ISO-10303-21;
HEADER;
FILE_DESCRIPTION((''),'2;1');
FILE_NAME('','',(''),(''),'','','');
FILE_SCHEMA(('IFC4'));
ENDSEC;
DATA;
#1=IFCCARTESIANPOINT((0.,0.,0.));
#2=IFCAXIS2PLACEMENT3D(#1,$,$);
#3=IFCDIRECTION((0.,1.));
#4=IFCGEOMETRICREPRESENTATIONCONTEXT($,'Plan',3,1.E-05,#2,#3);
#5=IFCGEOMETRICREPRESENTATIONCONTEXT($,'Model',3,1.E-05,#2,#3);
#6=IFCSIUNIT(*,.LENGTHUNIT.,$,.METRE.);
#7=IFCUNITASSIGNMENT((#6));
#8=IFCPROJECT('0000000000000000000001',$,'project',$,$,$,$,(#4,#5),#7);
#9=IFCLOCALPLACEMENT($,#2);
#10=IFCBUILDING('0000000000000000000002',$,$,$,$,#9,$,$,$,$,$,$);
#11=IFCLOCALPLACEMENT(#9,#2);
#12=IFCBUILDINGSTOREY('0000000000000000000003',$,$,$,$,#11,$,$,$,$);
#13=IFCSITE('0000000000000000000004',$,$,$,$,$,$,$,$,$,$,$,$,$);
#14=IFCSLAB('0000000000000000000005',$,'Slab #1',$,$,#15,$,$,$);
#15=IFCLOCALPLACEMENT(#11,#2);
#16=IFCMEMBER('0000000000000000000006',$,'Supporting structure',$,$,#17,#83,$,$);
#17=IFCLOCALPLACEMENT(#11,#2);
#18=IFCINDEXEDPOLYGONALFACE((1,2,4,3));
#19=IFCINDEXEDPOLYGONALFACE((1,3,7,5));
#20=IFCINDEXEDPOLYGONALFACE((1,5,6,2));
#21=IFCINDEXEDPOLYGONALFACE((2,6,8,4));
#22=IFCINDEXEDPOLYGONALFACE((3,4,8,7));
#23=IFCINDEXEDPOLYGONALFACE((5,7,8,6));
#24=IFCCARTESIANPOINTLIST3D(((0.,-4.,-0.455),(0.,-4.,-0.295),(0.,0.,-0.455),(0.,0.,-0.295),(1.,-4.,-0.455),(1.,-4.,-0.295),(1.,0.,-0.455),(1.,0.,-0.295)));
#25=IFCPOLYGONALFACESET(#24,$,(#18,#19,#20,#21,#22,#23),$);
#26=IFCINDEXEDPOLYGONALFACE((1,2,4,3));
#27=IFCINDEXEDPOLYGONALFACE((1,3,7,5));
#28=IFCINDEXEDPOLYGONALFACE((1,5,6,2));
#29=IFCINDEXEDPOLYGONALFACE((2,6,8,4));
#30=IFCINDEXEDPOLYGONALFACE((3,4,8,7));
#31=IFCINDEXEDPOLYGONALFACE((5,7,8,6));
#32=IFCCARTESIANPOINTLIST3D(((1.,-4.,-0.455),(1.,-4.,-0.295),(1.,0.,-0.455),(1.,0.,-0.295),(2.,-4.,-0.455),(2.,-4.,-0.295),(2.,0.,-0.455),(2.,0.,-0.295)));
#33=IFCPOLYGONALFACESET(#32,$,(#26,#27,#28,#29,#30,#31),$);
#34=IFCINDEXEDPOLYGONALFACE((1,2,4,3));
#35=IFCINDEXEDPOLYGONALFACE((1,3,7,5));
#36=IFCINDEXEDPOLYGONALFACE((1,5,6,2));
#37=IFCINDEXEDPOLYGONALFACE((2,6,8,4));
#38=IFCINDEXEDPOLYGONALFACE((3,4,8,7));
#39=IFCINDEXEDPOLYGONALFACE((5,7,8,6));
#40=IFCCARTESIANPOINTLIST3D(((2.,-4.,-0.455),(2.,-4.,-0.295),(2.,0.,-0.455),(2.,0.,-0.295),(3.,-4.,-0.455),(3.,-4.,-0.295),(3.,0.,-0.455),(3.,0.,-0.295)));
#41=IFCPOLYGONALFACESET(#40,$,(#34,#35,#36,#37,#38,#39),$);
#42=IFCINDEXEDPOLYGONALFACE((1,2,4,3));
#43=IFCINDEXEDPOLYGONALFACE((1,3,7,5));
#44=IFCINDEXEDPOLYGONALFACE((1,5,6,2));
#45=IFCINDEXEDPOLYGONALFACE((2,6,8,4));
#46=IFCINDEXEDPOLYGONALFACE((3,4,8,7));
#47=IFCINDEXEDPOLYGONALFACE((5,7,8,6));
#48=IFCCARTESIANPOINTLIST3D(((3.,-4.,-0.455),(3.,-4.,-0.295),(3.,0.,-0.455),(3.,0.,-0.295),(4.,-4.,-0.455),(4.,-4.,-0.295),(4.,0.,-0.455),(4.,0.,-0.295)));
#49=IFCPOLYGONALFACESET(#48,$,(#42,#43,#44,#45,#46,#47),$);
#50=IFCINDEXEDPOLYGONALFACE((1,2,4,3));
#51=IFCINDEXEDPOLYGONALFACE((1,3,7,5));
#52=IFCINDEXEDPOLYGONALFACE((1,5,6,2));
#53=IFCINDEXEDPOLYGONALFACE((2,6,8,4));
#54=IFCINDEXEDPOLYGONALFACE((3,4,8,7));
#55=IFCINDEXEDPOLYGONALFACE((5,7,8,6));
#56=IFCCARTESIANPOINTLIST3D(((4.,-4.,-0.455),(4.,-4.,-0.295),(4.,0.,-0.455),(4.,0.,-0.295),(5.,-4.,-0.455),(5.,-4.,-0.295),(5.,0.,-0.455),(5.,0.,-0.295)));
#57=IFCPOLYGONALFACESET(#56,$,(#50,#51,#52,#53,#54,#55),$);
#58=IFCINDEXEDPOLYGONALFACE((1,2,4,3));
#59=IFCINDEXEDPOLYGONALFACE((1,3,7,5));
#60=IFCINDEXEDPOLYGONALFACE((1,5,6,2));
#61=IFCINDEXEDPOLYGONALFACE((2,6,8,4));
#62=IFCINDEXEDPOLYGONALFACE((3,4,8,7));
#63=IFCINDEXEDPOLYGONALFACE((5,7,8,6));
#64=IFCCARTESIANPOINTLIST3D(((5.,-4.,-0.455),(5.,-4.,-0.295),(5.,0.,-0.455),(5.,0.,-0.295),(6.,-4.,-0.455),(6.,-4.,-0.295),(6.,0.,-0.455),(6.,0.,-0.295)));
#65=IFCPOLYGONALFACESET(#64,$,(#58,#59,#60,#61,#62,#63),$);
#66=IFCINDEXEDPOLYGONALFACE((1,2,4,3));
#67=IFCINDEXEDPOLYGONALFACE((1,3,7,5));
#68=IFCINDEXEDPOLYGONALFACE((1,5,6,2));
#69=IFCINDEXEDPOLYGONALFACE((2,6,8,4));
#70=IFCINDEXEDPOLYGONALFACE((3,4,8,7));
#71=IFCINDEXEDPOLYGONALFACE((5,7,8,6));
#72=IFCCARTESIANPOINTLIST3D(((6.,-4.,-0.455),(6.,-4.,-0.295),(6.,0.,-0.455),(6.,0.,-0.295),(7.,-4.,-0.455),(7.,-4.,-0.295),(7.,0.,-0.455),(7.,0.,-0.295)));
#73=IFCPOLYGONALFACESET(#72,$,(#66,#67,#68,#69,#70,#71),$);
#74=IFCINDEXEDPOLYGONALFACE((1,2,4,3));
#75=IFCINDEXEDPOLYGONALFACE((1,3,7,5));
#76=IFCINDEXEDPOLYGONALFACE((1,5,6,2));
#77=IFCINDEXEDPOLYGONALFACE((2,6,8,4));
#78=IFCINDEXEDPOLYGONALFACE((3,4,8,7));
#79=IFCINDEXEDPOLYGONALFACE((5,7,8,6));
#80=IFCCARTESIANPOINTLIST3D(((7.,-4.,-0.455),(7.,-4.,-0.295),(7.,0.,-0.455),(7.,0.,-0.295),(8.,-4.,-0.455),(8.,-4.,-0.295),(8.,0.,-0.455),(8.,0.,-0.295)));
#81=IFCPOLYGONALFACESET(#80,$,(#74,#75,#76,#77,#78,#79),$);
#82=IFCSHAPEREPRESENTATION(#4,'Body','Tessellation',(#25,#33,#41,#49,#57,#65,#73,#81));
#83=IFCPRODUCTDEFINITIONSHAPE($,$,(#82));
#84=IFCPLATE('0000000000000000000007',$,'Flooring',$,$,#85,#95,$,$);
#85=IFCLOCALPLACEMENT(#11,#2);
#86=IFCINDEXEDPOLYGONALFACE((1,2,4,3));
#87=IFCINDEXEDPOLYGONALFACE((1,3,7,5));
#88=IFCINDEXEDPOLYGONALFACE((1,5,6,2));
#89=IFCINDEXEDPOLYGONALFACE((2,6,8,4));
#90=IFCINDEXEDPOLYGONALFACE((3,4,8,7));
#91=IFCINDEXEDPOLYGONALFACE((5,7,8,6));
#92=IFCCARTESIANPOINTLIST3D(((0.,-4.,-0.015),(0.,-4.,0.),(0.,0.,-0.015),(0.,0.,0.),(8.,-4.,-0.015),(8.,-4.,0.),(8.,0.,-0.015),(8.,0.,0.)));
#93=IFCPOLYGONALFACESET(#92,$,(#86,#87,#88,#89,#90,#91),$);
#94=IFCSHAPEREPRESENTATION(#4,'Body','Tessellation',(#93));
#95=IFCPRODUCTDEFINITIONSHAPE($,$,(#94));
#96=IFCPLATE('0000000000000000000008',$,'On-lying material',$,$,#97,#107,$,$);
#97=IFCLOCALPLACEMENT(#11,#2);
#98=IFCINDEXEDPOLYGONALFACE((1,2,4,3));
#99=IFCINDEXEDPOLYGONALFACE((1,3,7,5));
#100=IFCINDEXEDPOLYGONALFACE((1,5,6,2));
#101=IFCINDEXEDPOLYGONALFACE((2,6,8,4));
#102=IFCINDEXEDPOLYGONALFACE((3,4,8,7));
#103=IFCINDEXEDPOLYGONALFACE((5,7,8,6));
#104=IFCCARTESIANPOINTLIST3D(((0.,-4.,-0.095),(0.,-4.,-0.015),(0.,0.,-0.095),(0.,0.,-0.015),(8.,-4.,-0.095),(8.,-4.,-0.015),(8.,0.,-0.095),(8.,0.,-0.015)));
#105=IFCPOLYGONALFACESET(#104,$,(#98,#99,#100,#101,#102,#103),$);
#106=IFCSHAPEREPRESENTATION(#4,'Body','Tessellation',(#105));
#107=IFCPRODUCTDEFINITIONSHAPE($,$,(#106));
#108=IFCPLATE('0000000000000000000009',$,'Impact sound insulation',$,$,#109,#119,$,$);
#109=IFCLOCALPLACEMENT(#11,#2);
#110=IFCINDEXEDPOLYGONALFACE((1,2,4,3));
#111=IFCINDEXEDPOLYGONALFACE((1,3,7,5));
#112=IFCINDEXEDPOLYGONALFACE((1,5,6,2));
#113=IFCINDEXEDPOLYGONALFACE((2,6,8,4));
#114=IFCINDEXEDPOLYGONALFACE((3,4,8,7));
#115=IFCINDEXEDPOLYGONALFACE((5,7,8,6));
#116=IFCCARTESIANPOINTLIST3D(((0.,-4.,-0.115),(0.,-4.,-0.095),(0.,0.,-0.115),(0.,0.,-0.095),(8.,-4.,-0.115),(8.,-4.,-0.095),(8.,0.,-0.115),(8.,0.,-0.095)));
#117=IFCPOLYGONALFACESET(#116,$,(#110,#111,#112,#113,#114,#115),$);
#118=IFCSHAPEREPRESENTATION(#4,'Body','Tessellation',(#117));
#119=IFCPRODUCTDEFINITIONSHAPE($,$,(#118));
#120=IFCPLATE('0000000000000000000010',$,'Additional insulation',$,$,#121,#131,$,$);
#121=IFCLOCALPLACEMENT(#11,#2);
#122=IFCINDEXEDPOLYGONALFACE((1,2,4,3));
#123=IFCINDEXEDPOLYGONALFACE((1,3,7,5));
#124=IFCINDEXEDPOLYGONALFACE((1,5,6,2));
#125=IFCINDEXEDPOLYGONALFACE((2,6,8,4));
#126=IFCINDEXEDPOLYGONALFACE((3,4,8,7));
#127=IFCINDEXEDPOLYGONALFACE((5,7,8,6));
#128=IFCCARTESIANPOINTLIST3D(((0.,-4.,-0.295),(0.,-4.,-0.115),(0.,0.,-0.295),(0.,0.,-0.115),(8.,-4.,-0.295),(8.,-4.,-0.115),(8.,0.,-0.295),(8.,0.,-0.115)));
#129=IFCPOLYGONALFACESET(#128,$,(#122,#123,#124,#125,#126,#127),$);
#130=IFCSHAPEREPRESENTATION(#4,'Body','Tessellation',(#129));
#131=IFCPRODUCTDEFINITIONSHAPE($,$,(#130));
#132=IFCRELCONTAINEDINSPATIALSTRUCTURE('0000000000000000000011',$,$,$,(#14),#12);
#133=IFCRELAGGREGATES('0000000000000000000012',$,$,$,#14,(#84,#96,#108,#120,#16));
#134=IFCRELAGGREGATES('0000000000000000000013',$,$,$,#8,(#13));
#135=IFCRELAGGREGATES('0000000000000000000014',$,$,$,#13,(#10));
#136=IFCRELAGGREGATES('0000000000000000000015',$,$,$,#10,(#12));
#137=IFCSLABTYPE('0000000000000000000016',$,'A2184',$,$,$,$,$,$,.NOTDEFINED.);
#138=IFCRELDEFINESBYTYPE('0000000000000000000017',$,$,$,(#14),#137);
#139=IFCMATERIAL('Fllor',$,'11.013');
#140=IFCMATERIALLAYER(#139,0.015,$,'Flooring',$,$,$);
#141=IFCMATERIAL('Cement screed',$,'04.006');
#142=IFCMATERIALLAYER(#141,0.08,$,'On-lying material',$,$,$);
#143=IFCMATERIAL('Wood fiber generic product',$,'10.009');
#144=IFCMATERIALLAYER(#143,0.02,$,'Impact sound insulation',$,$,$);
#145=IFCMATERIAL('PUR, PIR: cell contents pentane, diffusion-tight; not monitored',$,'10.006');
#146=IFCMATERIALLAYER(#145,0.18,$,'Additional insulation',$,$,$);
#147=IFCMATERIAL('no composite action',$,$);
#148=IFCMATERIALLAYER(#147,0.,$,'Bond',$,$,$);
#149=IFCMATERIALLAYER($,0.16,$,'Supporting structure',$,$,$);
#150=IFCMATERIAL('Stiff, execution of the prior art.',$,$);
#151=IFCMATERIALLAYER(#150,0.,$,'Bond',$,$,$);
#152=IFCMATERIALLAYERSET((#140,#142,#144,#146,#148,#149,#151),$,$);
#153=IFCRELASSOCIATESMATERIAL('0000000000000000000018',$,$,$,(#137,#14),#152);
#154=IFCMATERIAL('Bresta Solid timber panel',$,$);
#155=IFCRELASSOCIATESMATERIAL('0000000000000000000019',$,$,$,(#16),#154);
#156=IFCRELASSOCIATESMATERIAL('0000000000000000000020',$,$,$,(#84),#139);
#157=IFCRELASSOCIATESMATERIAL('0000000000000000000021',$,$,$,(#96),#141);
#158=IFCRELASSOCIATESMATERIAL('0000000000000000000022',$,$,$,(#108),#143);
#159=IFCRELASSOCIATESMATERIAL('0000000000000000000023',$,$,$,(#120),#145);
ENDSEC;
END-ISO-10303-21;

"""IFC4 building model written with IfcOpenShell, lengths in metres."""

from ifc_helpers import new_model, si_unit, direction, frame, frame_2d, origin, origin_with_axes, place, context, project, spatial, rectangle, extrude, material, layer, layer_set, type_object, element, aggregate, save


model = new_model("IFC4")

# Units and contexts
plan_context = context("Plan", 3, precision=1e-05, world=origin(), true_north=direction((0.0, 1.0)))
model_context = context("Model", 3, precision=1e-05, world=origin(), true_north=direction((0.0, 1.0)))
ifc_project = project(units=[si_unit("LENGTHUNIT", "METRE")], contexts=[plan_context, model_context])

# Site, building, storey
site = spatial("IfcSite", under=ifc_project)
building_placement = place(None, origin())
building = spatial("IfcBuilding", under=site, at=building_placement)
storey_placement = place(building_placement, origin())
storey = spatial("IfcBuildingStorey", under=building, at=storey_placement)

# Slab, member, plates
ifc_material_1 = material(Name="Fllor", Category="11.013")
ifc_layer_1 = layer(ifc_material_1, 0.015, Name="Flooring")
ifc_material_2 = material(Name="Cement screed", Category="04.006")
ifc_layer_2 = layer(ifc_material_2, 0.08, Name="On-lying material")
ifc_material_3 = material(Name="Wood fiber generic product", Category="10.009")
ifc_layer_3 = layer(ifc_material_3, 0.02, Name="Impact sound insulation")
ifc_material_4 = material(Name="PUR, PIR: cell contents pentane, diffusion-tight; not monitored", Category="10.006")
ifc_layer_4 = layer(ifc_material_4, 0.18, Name="Additional insulation")
ifc_material_5 = material(Name="no composite action")
ifc_layer_5 = layer(ifc_material_5, 0.0, Name="Bond")
ifc_layer_6 = layer(None, 0.16, Name="Supporting structure")
ifc_material_6 = material(Name="Stiff, execution of the prior art.")
ifc_layer_7 = layer(ifc_material_6, 0.0, Name="Bond")
ifc_layer_set = layer_set([ifc_layer_1, ifc_layer_2, ifc_layer_3, ifc_layer_4, ifc_layer_5, ifc_layer_6, ifc_layer_7])
slab_type = type_object("IfcSlabType", Name="A2184", PredefinedType="NOTDEFINED", material=ifc_layer_set)
slab_placement = place(None, frame((0.0, 0.0, 0.0), z_axis=(0.0, 0.0, -1.0), x_axis=(1.0, 0.0, 0.0)))
slab = element("IfcSlab", 1, at=slab_placement, inside=storey, type_object=slab_type, material=ifc_layer_set, Name="Slab #1")
ifc_material_7 = material(Name="Bresta Solid timber panel")
member_placement = place(slab_placement, origin())
member = element("IfcMember", 2, at=member_placement, material=ifc_material_7, Name="Supporting structure", context=plan_context, shape_type="SweptSolid", body=[
    extrude(rectangle(XDim=1.0, YDim=0.16, at=frame_2d((0.5, 0.08), x_axis=(1.0, 0.0))), frame((0.0, 4.0, 0.295), z_axis=(0.0, -1.0, 0.0), x_axis=(1.0, 0.0, 0.0)), (0.0, 0.0, 1.0), 4.0),
    extrude(rectangle(XDim=1.0, YDim=0.16, at=frame_2d((0.5, 0.08), x_axis=(1.0, 0.0))), frame((1.0, 4.0, 0.295), z_axis=(0.0, -1.0, 0.0), x_axis=(1.0, 0.0, 0.0)), (0.0, 0.0, 1.0), 4.0),
    extrude(rectangle(XDim=1.0, YDim=0.16, at=frame_2d((0.5, 0.08), x_axis=(1.0, 0.0))), frame((2.0, 4.0, 0.295), z_axis=(0.0, -1.0, 0.0), x_axis=(1.0, 0.0, 0.0)), (0.0, 0.0, 1.0), 4.0),
    extrude(rectangle(XDim=1.0, YDim=0.16, at=frame_2d((0.5, 0.08), x_axis=(1.0, 0.0))), frame((3.0, 4.0, 0.295), z_axis=(0.0, -1.0, 0.0), x_axis=(1.0, 0.0, 0.0)), (0.0, 0.0, 1.0), 4.0),
    extrude(rectangle(XDim=1.0, YDim=0.16, at=frame_2d((0.5, 0.08), x_axis=(1.0, 0.0))), frame((4.0, 4.0, 0.295), z_axis=(0.0, -1.0, 0.0), x_axis=(1.0, 0.0, 0.0)), (0.0, 0.0, 1.0), 4.0),
    extrude(rectangle(XDim=1.0, YDim=0.16, at=frame_2d((0.5, 0.08), x_axis=(1.0, 0.0))), frame((5.0, 4.0, 0.295), z_axis=(0.0, -1.0, 0.0), x_axis=(1.0, 0.0, 0.0)), (0.0, 0.0, 1.0), 4.0),
    extrude(rectangle(XDim=1.0, YDim=0.16, at=frame_2d((0.5, 0.08), x_axis=(1.0, 0.0))), frame((6.0, 4.0, 0.295), z_axis=(0.0, -1.0, 0.0), x_axis=(1.0, 0.0, 0.0)), (0.0, 0.0, 1.0), 4.0),
    extrude(rectangle(XDim=1.0, YDim=0.16, at=frame_2d((0.5, 0.08), x_axis=(1.0, 0.0))), frame((7.0, 4.0, 0.295), z_axis=(0.0, -1.0, 0.0), x_axis=(1.0, 0.0, 0.0)), (0.0, 0.0, 1.0), 4.0),
])
plate_1_placement = place(slab_placement, origin())
plate_1 = element("IfcPlate", 3, at=plate_1_placement, material=ifc_material_1, Name="Flooring", context=plan_context, shape_type="SweptSolid", body=[
    extrude(rectangle(XDim=8.0, YDim=4.0, at=frame_2d((4.0, 2.0), x_axis=(1.0, 0.0))), origin_with_axes(), (0.0, 0.0, 1.0), 0.015),
])
plate_2_placement = place(slab_placement, origin())
plate_2 = element("IfcPlate", 4, at=plate_2_placement, material=ifc_material_2, Name="On-lying material", context=plan_context, shape_type="SweptSolid", body=[
    extrude(rectangle(XDim=8.0, YDim=4.0, at=frame_2d((4.0, 2.0), x_axis=(1.0, 0.0))), frame((0.0, 0.0, 0.015), z_axis=(0.0, 0.0, 1.0), x_axis=(1.0, 0.0, 0.0)), (0.0, 0.0, 1.0), 0.08),
])
plate_3_placement = place(slab_placement, origin())
plate_3 = element("IfcPlate", 5, at=plate_3_placement, material=ifc_material_3, Name="Impact sound insulation", context=plan_context, shape_type="SweptSolid", body=[
    extrude(rectangle(XDim=8.0, YDim=4.0, at=frame_2d((4.0, 2.0), x_axis=(1.0, 0.0))), frame((0.0, 0.0, 0.095), z_axis=(0.0, 0.0, 1.0), x_axis=(1.0, 0.0, 0.0)), (0.0, 0.0, 1.0), 0.02),
])
plate_4_placement = place(slab_placement, origin())
plate_4 = element("IfcPlate", 6, at=plate_4_placement, material=ifc_material_4, Name="Additional insulation", context=plan_context, shape_type="SweptSolid", body=[
    extrude(rectangle(XDim=8.0, YDim=4.0, at=frame_2d((4.0, 2.0), x_axis=(1.0, 0.0))), frame((0.0, 0.0, 0.115), z_axis=(0.0, 0.0, 1.0), x_axis=(1.0, 0.0, 0.0)), (0.0, 0.0, 1.0), 0.18),
])
aggregate(slab, [plate_1, plate_2, plate_3, plate_4, member])

save(model, "model.ifc")
